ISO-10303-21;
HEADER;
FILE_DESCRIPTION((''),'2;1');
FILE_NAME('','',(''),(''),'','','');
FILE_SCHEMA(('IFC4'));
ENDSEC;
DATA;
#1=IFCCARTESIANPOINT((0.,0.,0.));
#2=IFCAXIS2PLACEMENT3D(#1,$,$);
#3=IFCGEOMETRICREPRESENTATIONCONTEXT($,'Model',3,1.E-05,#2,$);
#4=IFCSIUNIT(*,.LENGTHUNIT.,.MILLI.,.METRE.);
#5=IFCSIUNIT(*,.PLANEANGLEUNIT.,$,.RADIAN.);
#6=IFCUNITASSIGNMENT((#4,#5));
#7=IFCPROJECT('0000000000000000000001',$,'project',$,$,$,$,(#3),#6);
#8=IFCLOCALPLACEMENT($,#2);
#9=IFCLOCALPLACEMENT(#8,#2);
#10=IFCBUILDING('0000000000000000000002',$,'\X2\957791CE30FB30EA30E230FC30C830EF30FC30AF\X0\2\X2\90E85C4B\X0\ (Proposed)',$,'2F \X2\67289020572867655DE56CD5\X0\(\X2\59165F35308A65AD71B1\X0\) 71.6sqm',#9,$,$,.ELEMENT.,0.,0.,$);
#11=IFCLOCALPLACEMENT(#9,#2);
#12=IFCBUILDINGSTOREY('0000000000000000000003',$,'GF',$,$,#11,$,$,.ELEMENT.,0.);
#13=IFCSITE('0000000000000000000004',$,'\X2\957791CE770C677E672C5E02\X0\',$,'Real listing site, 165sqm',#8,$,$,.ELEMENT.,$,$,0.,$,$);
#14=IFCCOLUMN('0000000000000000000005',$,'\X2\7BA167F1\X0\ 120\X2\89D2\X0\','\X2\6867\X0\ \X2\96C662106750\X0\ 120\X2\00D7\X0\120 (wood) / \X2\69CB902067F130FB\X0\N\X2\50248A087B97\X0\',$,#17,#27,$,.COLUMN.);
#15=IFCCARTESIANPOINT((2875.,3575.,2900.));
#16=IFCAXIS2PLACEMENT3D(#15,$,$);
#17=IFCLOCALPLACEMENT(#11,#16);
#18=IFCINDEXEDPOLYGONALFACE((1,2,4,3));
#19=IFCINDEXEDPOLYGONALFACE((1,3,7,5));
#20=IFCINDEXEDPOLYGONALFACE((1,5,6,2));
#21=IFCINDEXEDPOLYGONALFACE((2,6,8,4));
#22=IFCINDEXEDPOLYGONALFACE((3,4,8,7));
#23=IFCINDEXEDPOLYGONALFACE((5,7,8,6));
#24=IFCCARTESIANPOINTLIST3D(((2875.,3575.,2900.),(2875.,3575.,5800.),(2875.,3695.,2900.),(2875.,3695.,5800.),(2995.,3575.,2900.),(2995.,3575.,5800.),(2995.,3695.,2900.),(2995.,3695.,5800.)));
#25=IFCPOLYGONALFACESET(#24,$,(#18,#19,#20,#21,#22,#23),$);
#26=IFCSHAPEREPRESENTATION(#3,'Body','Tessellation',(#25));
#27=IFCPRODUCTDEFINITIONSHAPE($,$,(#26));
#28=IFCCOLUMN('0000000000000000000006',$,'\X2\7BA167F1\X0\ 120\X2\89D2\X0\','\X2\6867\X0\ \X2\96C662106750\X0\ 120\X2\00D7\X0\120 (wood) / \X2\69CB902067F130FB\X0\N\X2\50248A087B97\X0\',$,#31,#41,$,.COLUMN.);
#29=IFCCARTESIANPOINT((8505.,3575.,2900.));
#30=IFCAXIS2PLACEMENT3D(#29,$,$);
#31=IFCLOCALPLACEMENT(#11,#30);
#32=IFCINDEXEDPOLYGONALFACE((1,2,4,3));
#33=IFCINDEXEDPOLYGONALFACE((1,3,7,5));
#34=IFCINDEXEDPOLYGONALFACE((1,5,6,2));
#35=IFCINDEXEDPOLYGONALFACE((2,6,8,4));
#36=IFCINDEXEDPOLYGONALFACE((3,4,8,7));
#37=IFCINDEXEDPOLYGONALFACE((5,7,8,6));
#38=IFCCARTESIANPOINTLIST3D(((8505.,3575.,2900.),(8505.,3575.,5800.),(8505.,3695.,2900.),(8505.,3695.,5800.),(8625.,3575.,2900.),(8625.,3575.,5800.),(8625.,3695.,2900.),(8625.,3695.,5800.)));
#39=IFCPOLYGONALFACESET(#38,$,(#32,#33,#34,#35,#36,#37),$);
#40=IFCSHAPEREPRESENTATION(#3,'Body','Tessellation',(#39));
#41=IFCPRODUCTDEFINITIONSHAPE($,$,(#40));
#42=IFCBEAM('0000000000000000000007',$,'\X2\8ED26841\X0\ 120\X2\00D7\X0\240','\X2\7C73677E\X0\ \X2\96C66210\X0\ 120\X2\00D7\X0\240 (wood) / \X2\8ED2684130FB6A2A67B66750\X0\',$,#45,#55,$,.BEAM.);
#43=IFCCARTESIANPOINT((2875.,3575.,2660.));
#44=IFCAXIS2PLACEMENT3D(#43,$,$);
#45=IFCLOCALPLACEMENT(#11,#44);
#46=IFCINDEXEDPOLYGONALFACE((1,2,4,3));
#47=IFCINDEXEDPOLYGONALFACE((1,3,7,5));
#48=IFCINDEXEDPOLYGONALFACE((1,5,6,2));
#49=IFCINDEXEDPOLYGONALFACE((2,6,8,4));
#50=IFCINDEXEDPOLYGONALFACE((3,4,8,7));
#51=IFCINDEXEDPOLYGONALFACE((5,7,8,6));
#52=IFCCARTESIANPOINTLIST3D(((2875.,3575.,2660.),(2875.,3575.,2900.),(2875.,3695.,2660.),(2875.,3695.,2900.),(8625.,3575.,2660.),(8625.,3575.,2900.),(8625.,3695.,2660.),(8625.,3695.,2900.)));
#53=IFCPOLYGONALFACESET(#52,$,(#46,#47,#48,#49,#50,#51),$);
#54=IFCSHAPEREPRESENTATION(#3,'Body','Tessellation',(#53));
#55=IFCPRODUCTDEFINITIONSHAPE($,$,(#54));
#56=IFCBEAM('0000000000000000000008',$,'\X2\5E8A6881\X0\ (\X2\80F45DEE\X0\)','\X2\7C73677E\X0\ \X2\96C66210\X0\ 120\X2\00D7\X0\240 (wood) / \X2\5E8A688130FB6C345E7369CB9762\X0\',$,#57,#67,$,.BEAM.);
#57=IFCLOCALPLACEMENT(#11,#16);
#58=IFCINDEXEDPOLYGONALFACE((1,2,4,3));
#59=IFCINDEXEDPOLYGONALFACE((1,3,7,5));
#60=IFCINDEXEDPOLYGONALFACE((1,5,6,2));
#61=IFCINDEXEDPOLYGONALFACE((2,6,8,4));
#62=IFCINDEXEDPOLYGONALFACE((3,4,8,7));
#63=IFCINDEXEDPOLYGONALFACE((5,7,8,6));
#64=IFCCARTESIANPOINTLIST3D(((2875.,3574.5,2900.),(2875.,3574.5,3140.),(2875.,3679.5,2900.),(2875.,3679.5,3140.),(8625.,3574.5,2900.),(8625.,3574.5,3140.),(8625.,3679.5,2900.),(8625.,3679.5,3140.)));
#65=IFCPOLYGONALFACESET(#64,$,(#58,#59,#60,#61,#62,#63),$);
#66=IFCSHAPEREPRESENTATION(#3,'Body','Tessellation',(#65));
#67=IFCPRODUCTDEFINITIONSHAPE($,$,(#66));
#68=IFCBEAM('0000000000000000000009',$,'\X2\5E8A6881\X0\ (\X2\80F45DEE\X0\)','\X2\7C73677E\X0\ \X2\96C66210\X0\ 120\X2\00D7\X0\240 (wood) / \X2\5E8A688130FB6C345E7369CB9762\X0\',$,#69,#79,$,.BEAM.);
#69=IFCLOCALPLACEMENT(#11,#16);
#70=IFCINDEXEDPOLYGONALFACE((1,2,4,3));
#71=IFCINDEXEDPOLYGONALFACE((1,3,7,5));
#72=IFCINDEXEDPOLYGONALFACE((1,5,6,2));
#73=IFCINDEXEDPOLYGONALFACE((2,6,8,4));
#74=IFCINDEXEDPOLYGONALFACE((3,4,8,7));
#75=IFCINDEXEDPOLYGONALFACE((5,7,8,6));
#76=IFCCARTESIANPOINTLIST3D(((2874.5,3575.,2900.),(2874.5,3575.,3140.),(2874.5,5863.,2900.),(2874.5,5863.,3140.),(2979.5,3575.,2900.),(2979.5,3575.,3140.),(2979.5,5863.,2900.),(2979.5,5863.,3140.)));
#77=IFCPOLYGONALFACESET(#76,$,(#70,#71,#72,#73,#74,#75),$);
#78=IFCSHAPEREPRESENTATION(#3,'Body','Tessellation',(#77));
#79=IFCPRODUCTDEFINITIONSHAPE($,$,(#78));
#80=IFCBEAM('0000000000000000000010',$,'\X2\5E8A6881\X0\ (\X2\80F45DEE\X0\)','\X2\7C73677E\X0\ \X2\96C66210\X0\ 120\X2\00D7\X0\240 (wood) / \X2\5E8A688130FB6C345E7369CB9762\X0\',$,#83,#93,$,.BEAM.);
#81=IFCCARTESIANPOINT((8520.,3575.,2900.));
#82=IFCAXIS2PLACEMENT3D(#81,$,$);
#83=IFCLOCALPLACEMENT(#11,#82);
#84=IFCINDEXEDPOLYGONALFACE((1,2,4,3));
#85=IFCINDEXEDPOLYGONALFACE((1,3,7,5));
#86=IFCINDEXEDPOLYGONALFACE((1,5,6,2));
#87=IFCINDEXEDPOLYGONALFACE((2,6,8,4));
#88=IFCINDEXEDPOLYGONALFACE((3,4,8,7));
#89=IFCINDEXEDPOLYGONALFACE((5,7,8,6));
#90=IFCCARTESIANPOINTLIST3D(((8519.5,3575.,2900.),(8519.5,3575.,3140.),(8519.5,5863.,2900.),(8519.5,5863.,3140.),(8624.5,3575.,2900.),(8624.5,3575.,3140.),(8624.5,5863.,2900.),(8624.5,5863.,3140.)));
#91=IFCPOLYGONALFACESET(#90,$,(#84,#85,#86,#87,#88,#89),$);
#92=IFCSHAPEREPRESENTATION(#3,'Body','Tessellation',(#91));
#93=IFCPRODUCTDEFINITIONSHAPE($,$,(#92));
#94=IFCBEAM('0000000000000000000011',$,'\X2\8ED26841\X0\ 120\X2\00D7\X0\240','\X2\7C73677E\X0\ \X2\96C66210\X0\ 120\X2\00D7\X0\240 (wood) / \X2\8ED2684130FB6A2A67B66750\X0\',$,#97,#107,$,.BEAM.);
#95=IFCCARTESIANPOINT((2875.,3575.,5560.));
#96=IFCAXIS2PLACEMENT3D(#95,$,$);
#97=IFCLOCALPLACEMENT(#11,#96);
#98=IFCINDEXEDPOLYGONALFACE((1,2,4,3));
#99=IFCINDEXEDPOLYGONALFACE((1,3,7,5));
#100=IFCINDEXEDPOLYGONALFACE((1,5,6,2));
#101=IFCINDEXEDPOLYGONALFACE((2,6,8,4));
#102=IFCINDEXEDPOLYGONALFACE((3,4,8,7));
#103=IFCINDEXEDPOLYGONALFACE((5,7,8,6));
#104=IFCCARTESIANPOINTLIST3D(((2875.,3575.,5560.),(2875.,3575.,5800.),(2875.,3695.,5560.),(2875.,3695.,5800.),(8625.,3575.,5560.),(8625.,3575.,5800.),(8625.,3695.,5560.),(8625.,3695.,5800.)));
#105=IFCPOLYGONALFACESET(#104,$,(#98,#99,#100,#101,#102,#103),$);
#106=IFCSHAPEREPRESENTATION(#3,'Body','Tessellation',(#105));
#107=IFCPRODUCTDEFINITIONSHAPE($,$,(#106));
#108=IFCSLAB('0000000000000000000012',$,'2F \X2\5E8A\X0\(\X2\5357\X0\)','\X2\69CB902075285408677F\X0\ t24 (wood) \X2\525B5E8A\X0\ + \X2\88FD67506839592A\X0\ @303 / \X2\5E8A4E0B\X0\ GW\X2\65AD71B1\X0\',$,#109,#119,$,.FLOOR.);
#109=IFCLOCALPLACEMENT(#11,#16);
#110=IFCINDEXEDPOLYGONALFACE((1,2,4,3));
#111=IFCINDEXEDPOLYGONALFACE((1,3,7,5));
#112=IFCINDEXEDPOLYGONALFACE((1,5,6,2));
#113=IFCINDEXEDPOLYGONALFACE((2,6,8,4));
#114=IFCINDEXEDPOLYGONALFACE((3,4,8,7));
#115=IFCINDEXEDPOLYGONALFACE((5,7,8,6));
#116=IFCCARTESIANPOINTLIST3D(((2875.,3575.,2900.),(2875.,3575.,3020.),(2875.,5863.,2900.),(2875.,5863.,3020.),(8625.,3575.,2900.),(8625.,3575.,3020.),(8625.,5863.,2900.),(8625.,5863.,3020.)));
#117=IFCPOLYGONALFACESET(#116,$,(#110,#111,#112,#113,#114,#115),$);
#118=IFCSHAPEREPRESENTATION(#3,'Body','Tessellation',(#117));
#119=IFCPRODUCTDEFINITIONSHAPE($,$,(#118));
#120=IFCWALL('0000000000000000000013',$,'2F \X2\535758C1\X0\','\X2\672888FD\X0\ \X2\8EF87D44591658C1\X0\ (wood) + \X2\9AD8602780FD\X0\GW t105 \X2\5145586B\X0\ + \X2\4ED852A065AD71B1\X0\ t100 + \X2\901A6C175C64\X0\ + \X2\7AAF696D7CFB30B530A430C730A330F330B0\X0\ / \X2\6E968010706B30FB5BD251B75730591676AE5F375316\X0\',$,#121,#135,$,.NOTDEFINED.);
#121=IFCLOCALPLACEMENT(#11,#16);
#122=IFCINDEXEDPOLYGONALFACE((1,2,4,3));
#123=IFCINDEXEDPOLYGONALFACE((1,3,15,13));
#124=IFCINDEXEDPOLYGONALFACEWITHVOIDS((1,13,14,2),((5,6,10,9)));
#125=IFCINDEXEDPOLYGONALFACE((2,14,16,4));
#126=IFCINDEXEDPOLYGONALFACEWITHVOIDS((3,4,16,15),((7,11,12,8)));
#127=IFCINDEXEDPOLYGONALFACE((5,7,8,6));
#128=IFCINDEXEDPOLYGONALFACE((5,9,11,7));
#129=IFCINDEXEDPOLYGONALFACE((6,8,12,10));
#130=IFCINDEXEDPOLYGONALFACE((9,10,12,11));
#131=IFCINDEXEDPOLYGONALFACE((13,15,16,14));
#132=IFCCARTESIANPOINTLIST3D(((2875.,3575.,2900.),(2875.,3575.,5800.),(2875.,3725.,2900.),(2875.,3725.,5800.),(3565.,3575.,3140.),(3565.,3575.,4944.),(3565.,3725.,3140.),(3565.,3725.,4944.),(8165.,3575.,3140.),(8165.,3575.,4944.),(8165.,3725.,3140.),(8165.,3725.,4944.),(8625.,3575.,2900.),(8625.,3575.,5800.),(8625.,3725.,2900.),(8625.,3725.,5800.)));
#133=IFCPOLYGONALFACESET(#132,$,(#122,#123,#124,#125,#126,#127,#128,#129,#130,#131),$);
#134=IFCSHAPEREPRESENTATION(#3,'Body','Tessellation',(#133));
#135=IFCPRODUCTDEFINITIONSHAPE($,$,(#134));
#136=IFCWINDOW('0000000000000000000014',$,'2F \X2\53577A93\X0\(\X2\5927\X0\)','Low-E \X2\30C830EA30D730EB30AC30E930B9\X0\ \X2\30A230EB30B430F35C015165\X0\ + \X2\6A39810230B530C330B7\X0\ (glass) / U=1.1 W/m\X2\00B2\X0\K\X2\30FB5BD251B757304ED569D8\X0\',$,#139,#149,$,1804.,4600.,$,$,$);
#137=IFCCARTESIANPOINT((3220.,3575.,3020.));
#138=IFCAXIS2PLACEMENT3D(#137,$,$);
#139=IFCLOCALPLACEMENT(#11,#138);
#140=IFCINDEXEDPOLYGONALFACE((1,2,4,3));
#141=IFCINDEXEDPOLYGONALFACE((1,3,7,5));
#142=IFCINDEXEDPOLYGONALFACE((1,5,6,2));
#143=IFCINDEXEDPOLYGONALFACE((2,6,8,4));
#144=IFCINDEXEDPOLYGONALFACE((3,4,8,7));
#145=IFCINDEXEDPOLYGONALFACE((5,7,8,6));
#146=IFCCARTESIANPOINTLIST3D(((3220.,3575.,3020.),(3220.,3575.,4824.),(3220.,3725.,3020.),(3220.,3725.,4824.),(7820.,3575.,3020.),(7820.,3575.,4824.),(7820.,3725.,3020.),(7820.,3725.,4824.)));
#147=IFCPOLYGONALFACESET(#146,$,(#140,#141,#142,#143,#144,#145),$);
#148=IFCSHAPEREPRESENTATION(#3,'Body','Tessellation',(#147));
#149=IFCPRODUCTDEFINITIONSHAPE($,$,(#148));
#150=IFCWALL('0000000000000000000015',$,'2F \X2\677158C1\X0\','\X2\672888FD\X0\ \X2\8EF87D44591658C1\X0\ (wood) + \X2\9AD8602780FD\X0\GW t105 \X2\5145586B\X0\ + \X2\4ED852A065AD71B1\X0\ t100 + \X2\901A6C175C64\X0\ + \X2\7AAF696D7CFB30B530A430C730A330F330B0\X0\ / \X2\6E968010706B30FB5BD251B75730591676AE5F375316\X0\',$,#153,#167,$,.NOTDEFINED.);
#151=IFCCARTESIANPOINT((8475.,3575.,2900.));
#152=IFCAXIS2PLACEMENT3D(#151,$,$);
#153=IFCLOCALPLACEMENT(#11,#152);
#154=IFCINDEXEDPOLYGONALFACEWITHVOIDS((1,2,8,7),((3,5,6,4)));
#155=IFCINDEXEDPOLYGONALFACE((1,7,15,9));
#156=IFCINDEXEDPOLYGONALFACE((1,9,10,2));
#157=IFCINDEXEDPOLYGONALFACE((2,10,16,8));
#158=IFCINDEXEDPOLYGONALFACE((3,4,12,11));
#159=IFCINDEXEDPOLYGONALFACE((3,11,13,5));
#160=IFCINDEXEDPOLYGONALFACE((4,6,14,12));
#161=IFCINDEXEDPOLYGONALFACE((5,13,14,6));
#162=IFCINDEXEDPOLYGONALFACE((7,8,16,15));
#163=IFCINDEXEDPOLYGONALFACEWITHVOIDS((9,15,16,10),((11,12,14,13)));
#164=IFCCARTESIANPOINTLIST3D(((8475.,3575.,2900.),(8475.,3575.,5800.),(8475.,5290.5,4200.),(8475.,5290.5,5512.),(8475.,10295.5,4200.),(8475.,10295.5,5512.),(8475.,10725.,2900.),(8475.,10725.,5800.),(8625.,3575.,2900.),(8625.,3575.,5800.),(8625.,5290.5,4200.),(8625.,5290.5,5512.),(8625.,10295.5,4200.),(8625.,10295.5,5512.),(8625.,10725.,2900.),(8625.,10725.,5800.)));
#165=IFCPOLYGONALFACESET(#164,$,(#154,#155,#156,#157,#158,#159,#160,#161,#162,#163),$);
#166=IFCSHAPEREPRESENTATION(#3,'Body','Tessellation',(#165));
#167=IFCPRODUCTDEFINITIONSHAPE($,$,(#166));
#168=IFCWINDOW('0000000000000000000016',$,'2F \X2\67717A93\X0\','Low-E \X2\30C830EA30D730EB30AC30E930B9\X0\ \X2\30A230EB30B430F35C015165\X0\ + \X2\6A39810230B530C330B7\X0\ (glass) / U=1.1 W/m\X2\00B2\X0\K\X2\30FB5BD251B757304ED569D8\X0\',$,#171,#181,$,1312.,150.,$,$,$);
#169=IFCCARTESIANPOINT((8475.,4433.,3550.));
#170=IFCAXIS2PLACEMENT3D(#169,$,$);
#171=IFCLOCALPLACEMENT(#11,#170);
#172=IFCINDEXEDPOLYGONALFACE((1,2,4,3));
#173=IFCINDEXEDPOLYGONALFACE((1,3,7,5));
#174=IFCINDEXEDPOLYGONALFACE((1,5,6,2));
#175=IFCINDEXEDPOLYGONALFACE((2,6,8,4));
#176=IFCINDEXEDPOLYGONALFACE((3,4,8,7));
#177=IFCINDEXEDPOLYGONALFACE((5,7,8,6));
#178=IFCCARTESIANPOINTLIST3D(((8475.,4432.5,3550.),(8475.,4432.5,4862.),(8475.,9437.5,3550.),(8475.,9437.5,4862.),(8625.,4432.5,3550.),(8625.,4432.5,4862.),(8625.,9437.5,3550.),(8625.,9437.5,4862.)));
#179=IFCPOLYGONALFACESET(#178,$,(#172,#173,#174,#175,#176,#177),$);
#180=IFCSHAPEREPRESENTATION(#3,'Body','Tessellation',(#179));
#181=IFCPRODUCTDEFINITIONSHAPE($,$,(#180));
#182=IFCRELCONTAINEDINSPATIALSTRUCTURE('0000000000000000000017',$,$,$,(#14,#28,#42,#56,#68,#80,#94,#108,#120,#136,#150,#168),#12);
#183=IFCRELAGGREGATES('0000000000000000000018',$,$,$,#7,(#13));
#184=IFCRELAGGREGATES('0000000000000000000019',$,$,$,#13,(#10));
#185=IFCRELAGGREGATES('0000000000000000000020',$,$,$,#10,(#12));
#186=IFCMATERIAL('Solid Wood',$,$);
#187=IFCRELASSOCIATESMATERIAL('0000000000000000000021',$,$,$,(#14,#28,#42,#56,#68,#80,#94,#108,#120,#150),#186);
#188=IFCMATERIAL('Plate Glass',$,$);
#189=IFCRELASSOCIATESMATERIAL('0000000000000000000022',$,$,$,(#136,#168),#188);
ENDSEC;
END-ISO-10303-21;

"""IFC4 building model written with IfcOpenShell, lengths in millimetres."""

from ifc_helpers import new_model, si_unit, frame, frame_2d, origin, place, context, project, spatial, rectangle, extrude, material, element, fill, save


model = new_model("IFC4")

# Units and contexts
model_context = context("Model", 3, precision=1e-05, world=origin())
ifc_project = project(units=[si_unit("LENGTHUNIT", "METRE", prefix="MILLI"), si_unit("PLANEANGLEUNIT", "RADIAN")], contexts=[model_context])

# Site, building, storey
site_placement = place(None, origin())
site = spatial("IfcSite", under=ifc_project, at=site_placement, Name="長野県松本市", ObjectType="Real listing site, 165sqm", CompositionType="ELEMENT", RefElevation=0.0)
building_placement = place(site_placement, origin())
building = spatial("IfcBuilding", under=site, at=building_placement, Name="長野・リモートワーク2部屋 (Proposed)", ObjectType="2F 木造在来工法(外張り断熱) 71.6sqm", CompositionType="ELEMENT", ElevationOfRefHeight=0.0, ElevationOfTerrain=0.0)
storey_placement = place(building_placement, origin())
storey = spatial("IfcBuildingStorey", under=building, at=storey_placement, Name="GF", CompositionType="ELEMENT", Elevation=0.0)

# Columns
ifc_material_1 = material(Name="Solid Wood")
column_1_placement = place(storey_placement, frame((2875.0, 3575.0, 2900.0)))
element("IfcColumn", 1, at=column_1_placement, inside=storey, material=ifc_material_1, Name="管柱 120角", Description="桧 集成材 120×120 (wood) / 構造柱・N値計算", PredefinedType="COLUMN", context=model_context, shape_type="SweptSolid", body=[
    extrude(rectangle(XDim=120.0, YDim=120.0, at=frame_2d((60.0, 60.0))), frame((2875.0, 3575.0, 2900.0)), (0.0, 0.0, 1.0), 2900.0),
])
column_2_placement = place(storey_placement, frame((8505.0, 3575.0, 2900.0)))
element("IfcColumn", 2, at=column_2_placement, inside=storey, material=ifc_material_1, Name="管柱 120角", Description="桧 集成材 120×120 (wood) / 構造柱・N値計算", PredefinedType="COLUMN", context=model_context, shape_type="SweptSolid", body=[
    extrude(rectangle(XDim=120.0, YDim=120.0, at=frame_2d((60.0, 60.0))), frame((8505.0, 3575.0, 2900.0)), (0.0, 0.0, 1.0), 2900.0),
])

# Beams
beam_1_placement = place(storey_placement, frame((2875.0, 3575.0, 2660.0)))
element("IfcBeam", 3, at=beam_1_placement, inside=storey, material=ifc_material_1, Name="軒桁 120×240", Description="米松 集成 120×240 (wood) / 軒桁・横架材", PredefinedType="BEAM", context=model_context, shape_type="SweptSolid", body=[
    extrude(rectangle(XDim=5750.0, YDim=120.0, at=frame_2d((2875.0, 60.0))), frame((2875.0, 3575.0, 2660.0)), (0.0, 0.0, 1.0), 240.0),
])
beam_2_placement = place(storey_placement, frame((2875.0, 3575.0, 2900.0)))
element("IfcBeam", 4, at=beam_2_placement, inside=storey, material=ifc_material_1, Name="床梁 (胴差)", Description="米松 集成 120×240 (wood) / 床梁・水平構面", PredefinedType="BEAM", context=model_context, shape_type="SweptSolid", body=[
    extrude(rectangle(XDim=5750.0, YDim=105.0, at=frame_2d((2875.0, 52.0))), frame((2875.0, 3575.0, 2900.0)), (0.0, 0.0, 1.0), 240.0),
])
beam_3_placement = place(storey_placement, frame((2875.0, 3575.0, 2900.0)))
element("IfcBeam", 5, at=beam_3_placement, inside=storey, material=ifc_material_1, Name="床梁 (胴差)", Description="米松 集成 120×240 (wood) / 床梁・水平構面", PredefinedType="BEAM", context=model_context, shape_type="SweptSolid", body=[
    extrude(rectangle(XDim=105.0, YDim=2288.0, at=frame_2d((52.0, 1144.0))), frame((2875.0, 3575.0, 2900.0)), (0.0, 0.0, 1.0), 240.0),
])
beam_4_placement = place(storey_placement, frame((8520.0, 3575.0, 2900.0)))
element("IfcBeam", 6, at=beam_4_placement, inside=storey, material=ifc_material_1, Name="床梁 (胴差)", Description="米松 集成 120×240 (wood) / 床梁・水平構面", PredefinedType="BEAM", context=model_context, shape_type="SweptSolid", body=[
    extrude(rectangle(XDim=105.0, YDim=2288.0, at=frame_2d((52.0, 1144.0))), frame((8520.0, 3575.0, 2900.0)), (0.0, 0.0, 1.0), 240.0),
])
beam_5_placement = place(storey_placement, frame((2875.0, 3575.0, 5560.0)))
element("IfcBeam", 7, at=beam_5_placement, inside=storey, material=ifc_material_1, Name="軒桁 120×240", Description="米松 集成 120×240 (wood) / 軒桁・横架材", PredefinedType="BEAM", context=model_context, shape_type="SweptSolid", body=[
    extrude(rectangle(XDim=5750.0, YDim=120.0, at=frame_2d((2875.0, 60.0))), frame((2875.0, 3575.0, 5560.0)), (0.0, 0.0, 1.0), 240.0),
])

# Slab
slab_placement = place(storey_placement, frame((2875.0, 3575.0, 2900.0)))
element("IfcSlab", 8, at=slab_placement, inside=storey, material=ifc_material_1, Name="2F 床(南)", Description="構造用合板 t24 (wood) 剛床 + 製材根太 @303 / 床下 GW断熱", PredefinedType="FLOOR", context=model_context, shape_type="SweptSolid", body=[
    extrude(rectangle(XDim=5750.0, YDim=2288.0, at=frame_2d((2875.0, 1144.0))), frame((2875.0, 3575.0, 2900.0)), (0.0, 0.0, 1.0), 120.0),
])

# Walls, openings, windows
wall_1_placement = place(storey_placement, frame((2875.0, 3575.0, 2900.0)))
wall_1 = element("IfcWall", 9, at=wall_1_placement, inside=storey, material=ifc_material_1, Name="2F 南壁", Description="木製 軸組外壁 (wood) + 高性能GW t105 充填 + 付加断熱 t100 + 通気層 + 窯業系サイディング / 準耐火・寒冷地外皮強化", PredefinedType="NOTDEFINED", context=model_context, shape_type="SweptSolid", body=[
    extrude(rectangle(XDim=5750.0, YDim=150.0, at=frame_2d((2875.0, 75.0))), frame((2875.0, 3575.0, 2900.0)), (0.0, 0.0, 1.0), 2900.0),
])
opening_1_placement = place(storey_placement, frame((3220.0, 3575.0, 3020.0)))
opening_1 = element("IfcOpeningElement", 10, at=opening_1_placement, cuts=wall_1, PredefinedType="NOTDEFINED", context=model_context, shape_type="SweptSolid", body=[
    extrude(rectangle(XDim=4600.0, YDim=150.0, at=frame_2d((2300.0, 75.0))), frame((3220.0, 3575.0, 3020.0)), (0.0, 0.0, 1.0), 1804.0),
])
ifc_material_2 = material(Name="Plate Glass")
window_1_placement = place(storey_placement, frame((3220.0, 3575.0, 3020.0)))
window_1 = element("IfcWindow", 11, at=window_1_placement, inside=storey, material=ifc_material_2, Name="2F 南窓(大)", Description="Low-E トリプルガラス アルゴン封入 + 樹脂サッシ (glass) / U=1.1 W/m²K・寒冷地仕様", OverallHeight=1804.0, OverallWidth=4600.0, context=model_context, shape_type="SweptSolid", body=[
    extrude(rectangle(XDim=4600.0, YDim=150.0, at=frame_2d((2300.0, 75.0))), frame((3220.0, 3575.0, 3020.0)), (0.0, 0.0, 1.0), 1804.0),
])
fill(opening_1, window_1)
wall_2_placement = place(storey_placement, frame((8475.0, 3575.0, 2900.0)))
wall_2 = element("IfcWall", 12, at=wall_2_placement, inside=storey, material=ifc_material_1, Name="2F 東壁", Description="木製 軸組外壁 (wood) + 高性能GW t105 充填 + 付加断熱 t100 + 通気層 + 窯業系サイディング / 準耐火・寒冷地外皮強化", PredefinedType="NOTDEFINED", context=model_context, shape_type="SweptSolid", body=[
    extrude(rectangle(XDim=150.0, YDim=7150.0, at=frame_2d((75.0, 3575.0))), frame((8475.0, 3575.0, 2900.0)), (0.0, 0.0, 1.0), 2900.0),
])
opening_2_placement = place(storey_placement, frame((8475.0, 4433.0, 3550.0)))
opening_2 = element("IfcOpeningElement", 13, at=opening_2_placement, cuts=wall_2, PredefinedType="NOTDEFINED", context=model_context, shape_type="SweptSolid", body=[
    extrude(rectangle(XDim=150.0, YDim=5005.0, at=frame_2d((75.0, 2502.0))), frame((8475.0, 4433.0, 3550.0)), (0.0, 0.0, 1.0), 1312.0),
])
window_2_placement = place(storey_placement, frame((8475.0, 4433.0, 3550.0)))
window_2 = element("IfcWindow", 14, at=window_2_placement, inside=storey, material=ifc_material_2, Name="2F 東窓", Description="Low-E トリプルガラス アルゴン封入 + 樹脂サッシ (glass) / U=1.1 W/m²K・寒冷地仕様", OverallHeight=1312.0, OverallWidth=150.0, context=model_context, shape_type="SweptSolid", body=[
    extrude(rectangle(XDim=150.0, YDim=5005.0, at=frame_2d((75.0, 2502.0))), frame((8475.0, 4433.0, 3550.0)), (0.0, 0.0, 1.0), 1312.0),
])
fill(opening_2, window_2)

save(model, "model.ifc")
